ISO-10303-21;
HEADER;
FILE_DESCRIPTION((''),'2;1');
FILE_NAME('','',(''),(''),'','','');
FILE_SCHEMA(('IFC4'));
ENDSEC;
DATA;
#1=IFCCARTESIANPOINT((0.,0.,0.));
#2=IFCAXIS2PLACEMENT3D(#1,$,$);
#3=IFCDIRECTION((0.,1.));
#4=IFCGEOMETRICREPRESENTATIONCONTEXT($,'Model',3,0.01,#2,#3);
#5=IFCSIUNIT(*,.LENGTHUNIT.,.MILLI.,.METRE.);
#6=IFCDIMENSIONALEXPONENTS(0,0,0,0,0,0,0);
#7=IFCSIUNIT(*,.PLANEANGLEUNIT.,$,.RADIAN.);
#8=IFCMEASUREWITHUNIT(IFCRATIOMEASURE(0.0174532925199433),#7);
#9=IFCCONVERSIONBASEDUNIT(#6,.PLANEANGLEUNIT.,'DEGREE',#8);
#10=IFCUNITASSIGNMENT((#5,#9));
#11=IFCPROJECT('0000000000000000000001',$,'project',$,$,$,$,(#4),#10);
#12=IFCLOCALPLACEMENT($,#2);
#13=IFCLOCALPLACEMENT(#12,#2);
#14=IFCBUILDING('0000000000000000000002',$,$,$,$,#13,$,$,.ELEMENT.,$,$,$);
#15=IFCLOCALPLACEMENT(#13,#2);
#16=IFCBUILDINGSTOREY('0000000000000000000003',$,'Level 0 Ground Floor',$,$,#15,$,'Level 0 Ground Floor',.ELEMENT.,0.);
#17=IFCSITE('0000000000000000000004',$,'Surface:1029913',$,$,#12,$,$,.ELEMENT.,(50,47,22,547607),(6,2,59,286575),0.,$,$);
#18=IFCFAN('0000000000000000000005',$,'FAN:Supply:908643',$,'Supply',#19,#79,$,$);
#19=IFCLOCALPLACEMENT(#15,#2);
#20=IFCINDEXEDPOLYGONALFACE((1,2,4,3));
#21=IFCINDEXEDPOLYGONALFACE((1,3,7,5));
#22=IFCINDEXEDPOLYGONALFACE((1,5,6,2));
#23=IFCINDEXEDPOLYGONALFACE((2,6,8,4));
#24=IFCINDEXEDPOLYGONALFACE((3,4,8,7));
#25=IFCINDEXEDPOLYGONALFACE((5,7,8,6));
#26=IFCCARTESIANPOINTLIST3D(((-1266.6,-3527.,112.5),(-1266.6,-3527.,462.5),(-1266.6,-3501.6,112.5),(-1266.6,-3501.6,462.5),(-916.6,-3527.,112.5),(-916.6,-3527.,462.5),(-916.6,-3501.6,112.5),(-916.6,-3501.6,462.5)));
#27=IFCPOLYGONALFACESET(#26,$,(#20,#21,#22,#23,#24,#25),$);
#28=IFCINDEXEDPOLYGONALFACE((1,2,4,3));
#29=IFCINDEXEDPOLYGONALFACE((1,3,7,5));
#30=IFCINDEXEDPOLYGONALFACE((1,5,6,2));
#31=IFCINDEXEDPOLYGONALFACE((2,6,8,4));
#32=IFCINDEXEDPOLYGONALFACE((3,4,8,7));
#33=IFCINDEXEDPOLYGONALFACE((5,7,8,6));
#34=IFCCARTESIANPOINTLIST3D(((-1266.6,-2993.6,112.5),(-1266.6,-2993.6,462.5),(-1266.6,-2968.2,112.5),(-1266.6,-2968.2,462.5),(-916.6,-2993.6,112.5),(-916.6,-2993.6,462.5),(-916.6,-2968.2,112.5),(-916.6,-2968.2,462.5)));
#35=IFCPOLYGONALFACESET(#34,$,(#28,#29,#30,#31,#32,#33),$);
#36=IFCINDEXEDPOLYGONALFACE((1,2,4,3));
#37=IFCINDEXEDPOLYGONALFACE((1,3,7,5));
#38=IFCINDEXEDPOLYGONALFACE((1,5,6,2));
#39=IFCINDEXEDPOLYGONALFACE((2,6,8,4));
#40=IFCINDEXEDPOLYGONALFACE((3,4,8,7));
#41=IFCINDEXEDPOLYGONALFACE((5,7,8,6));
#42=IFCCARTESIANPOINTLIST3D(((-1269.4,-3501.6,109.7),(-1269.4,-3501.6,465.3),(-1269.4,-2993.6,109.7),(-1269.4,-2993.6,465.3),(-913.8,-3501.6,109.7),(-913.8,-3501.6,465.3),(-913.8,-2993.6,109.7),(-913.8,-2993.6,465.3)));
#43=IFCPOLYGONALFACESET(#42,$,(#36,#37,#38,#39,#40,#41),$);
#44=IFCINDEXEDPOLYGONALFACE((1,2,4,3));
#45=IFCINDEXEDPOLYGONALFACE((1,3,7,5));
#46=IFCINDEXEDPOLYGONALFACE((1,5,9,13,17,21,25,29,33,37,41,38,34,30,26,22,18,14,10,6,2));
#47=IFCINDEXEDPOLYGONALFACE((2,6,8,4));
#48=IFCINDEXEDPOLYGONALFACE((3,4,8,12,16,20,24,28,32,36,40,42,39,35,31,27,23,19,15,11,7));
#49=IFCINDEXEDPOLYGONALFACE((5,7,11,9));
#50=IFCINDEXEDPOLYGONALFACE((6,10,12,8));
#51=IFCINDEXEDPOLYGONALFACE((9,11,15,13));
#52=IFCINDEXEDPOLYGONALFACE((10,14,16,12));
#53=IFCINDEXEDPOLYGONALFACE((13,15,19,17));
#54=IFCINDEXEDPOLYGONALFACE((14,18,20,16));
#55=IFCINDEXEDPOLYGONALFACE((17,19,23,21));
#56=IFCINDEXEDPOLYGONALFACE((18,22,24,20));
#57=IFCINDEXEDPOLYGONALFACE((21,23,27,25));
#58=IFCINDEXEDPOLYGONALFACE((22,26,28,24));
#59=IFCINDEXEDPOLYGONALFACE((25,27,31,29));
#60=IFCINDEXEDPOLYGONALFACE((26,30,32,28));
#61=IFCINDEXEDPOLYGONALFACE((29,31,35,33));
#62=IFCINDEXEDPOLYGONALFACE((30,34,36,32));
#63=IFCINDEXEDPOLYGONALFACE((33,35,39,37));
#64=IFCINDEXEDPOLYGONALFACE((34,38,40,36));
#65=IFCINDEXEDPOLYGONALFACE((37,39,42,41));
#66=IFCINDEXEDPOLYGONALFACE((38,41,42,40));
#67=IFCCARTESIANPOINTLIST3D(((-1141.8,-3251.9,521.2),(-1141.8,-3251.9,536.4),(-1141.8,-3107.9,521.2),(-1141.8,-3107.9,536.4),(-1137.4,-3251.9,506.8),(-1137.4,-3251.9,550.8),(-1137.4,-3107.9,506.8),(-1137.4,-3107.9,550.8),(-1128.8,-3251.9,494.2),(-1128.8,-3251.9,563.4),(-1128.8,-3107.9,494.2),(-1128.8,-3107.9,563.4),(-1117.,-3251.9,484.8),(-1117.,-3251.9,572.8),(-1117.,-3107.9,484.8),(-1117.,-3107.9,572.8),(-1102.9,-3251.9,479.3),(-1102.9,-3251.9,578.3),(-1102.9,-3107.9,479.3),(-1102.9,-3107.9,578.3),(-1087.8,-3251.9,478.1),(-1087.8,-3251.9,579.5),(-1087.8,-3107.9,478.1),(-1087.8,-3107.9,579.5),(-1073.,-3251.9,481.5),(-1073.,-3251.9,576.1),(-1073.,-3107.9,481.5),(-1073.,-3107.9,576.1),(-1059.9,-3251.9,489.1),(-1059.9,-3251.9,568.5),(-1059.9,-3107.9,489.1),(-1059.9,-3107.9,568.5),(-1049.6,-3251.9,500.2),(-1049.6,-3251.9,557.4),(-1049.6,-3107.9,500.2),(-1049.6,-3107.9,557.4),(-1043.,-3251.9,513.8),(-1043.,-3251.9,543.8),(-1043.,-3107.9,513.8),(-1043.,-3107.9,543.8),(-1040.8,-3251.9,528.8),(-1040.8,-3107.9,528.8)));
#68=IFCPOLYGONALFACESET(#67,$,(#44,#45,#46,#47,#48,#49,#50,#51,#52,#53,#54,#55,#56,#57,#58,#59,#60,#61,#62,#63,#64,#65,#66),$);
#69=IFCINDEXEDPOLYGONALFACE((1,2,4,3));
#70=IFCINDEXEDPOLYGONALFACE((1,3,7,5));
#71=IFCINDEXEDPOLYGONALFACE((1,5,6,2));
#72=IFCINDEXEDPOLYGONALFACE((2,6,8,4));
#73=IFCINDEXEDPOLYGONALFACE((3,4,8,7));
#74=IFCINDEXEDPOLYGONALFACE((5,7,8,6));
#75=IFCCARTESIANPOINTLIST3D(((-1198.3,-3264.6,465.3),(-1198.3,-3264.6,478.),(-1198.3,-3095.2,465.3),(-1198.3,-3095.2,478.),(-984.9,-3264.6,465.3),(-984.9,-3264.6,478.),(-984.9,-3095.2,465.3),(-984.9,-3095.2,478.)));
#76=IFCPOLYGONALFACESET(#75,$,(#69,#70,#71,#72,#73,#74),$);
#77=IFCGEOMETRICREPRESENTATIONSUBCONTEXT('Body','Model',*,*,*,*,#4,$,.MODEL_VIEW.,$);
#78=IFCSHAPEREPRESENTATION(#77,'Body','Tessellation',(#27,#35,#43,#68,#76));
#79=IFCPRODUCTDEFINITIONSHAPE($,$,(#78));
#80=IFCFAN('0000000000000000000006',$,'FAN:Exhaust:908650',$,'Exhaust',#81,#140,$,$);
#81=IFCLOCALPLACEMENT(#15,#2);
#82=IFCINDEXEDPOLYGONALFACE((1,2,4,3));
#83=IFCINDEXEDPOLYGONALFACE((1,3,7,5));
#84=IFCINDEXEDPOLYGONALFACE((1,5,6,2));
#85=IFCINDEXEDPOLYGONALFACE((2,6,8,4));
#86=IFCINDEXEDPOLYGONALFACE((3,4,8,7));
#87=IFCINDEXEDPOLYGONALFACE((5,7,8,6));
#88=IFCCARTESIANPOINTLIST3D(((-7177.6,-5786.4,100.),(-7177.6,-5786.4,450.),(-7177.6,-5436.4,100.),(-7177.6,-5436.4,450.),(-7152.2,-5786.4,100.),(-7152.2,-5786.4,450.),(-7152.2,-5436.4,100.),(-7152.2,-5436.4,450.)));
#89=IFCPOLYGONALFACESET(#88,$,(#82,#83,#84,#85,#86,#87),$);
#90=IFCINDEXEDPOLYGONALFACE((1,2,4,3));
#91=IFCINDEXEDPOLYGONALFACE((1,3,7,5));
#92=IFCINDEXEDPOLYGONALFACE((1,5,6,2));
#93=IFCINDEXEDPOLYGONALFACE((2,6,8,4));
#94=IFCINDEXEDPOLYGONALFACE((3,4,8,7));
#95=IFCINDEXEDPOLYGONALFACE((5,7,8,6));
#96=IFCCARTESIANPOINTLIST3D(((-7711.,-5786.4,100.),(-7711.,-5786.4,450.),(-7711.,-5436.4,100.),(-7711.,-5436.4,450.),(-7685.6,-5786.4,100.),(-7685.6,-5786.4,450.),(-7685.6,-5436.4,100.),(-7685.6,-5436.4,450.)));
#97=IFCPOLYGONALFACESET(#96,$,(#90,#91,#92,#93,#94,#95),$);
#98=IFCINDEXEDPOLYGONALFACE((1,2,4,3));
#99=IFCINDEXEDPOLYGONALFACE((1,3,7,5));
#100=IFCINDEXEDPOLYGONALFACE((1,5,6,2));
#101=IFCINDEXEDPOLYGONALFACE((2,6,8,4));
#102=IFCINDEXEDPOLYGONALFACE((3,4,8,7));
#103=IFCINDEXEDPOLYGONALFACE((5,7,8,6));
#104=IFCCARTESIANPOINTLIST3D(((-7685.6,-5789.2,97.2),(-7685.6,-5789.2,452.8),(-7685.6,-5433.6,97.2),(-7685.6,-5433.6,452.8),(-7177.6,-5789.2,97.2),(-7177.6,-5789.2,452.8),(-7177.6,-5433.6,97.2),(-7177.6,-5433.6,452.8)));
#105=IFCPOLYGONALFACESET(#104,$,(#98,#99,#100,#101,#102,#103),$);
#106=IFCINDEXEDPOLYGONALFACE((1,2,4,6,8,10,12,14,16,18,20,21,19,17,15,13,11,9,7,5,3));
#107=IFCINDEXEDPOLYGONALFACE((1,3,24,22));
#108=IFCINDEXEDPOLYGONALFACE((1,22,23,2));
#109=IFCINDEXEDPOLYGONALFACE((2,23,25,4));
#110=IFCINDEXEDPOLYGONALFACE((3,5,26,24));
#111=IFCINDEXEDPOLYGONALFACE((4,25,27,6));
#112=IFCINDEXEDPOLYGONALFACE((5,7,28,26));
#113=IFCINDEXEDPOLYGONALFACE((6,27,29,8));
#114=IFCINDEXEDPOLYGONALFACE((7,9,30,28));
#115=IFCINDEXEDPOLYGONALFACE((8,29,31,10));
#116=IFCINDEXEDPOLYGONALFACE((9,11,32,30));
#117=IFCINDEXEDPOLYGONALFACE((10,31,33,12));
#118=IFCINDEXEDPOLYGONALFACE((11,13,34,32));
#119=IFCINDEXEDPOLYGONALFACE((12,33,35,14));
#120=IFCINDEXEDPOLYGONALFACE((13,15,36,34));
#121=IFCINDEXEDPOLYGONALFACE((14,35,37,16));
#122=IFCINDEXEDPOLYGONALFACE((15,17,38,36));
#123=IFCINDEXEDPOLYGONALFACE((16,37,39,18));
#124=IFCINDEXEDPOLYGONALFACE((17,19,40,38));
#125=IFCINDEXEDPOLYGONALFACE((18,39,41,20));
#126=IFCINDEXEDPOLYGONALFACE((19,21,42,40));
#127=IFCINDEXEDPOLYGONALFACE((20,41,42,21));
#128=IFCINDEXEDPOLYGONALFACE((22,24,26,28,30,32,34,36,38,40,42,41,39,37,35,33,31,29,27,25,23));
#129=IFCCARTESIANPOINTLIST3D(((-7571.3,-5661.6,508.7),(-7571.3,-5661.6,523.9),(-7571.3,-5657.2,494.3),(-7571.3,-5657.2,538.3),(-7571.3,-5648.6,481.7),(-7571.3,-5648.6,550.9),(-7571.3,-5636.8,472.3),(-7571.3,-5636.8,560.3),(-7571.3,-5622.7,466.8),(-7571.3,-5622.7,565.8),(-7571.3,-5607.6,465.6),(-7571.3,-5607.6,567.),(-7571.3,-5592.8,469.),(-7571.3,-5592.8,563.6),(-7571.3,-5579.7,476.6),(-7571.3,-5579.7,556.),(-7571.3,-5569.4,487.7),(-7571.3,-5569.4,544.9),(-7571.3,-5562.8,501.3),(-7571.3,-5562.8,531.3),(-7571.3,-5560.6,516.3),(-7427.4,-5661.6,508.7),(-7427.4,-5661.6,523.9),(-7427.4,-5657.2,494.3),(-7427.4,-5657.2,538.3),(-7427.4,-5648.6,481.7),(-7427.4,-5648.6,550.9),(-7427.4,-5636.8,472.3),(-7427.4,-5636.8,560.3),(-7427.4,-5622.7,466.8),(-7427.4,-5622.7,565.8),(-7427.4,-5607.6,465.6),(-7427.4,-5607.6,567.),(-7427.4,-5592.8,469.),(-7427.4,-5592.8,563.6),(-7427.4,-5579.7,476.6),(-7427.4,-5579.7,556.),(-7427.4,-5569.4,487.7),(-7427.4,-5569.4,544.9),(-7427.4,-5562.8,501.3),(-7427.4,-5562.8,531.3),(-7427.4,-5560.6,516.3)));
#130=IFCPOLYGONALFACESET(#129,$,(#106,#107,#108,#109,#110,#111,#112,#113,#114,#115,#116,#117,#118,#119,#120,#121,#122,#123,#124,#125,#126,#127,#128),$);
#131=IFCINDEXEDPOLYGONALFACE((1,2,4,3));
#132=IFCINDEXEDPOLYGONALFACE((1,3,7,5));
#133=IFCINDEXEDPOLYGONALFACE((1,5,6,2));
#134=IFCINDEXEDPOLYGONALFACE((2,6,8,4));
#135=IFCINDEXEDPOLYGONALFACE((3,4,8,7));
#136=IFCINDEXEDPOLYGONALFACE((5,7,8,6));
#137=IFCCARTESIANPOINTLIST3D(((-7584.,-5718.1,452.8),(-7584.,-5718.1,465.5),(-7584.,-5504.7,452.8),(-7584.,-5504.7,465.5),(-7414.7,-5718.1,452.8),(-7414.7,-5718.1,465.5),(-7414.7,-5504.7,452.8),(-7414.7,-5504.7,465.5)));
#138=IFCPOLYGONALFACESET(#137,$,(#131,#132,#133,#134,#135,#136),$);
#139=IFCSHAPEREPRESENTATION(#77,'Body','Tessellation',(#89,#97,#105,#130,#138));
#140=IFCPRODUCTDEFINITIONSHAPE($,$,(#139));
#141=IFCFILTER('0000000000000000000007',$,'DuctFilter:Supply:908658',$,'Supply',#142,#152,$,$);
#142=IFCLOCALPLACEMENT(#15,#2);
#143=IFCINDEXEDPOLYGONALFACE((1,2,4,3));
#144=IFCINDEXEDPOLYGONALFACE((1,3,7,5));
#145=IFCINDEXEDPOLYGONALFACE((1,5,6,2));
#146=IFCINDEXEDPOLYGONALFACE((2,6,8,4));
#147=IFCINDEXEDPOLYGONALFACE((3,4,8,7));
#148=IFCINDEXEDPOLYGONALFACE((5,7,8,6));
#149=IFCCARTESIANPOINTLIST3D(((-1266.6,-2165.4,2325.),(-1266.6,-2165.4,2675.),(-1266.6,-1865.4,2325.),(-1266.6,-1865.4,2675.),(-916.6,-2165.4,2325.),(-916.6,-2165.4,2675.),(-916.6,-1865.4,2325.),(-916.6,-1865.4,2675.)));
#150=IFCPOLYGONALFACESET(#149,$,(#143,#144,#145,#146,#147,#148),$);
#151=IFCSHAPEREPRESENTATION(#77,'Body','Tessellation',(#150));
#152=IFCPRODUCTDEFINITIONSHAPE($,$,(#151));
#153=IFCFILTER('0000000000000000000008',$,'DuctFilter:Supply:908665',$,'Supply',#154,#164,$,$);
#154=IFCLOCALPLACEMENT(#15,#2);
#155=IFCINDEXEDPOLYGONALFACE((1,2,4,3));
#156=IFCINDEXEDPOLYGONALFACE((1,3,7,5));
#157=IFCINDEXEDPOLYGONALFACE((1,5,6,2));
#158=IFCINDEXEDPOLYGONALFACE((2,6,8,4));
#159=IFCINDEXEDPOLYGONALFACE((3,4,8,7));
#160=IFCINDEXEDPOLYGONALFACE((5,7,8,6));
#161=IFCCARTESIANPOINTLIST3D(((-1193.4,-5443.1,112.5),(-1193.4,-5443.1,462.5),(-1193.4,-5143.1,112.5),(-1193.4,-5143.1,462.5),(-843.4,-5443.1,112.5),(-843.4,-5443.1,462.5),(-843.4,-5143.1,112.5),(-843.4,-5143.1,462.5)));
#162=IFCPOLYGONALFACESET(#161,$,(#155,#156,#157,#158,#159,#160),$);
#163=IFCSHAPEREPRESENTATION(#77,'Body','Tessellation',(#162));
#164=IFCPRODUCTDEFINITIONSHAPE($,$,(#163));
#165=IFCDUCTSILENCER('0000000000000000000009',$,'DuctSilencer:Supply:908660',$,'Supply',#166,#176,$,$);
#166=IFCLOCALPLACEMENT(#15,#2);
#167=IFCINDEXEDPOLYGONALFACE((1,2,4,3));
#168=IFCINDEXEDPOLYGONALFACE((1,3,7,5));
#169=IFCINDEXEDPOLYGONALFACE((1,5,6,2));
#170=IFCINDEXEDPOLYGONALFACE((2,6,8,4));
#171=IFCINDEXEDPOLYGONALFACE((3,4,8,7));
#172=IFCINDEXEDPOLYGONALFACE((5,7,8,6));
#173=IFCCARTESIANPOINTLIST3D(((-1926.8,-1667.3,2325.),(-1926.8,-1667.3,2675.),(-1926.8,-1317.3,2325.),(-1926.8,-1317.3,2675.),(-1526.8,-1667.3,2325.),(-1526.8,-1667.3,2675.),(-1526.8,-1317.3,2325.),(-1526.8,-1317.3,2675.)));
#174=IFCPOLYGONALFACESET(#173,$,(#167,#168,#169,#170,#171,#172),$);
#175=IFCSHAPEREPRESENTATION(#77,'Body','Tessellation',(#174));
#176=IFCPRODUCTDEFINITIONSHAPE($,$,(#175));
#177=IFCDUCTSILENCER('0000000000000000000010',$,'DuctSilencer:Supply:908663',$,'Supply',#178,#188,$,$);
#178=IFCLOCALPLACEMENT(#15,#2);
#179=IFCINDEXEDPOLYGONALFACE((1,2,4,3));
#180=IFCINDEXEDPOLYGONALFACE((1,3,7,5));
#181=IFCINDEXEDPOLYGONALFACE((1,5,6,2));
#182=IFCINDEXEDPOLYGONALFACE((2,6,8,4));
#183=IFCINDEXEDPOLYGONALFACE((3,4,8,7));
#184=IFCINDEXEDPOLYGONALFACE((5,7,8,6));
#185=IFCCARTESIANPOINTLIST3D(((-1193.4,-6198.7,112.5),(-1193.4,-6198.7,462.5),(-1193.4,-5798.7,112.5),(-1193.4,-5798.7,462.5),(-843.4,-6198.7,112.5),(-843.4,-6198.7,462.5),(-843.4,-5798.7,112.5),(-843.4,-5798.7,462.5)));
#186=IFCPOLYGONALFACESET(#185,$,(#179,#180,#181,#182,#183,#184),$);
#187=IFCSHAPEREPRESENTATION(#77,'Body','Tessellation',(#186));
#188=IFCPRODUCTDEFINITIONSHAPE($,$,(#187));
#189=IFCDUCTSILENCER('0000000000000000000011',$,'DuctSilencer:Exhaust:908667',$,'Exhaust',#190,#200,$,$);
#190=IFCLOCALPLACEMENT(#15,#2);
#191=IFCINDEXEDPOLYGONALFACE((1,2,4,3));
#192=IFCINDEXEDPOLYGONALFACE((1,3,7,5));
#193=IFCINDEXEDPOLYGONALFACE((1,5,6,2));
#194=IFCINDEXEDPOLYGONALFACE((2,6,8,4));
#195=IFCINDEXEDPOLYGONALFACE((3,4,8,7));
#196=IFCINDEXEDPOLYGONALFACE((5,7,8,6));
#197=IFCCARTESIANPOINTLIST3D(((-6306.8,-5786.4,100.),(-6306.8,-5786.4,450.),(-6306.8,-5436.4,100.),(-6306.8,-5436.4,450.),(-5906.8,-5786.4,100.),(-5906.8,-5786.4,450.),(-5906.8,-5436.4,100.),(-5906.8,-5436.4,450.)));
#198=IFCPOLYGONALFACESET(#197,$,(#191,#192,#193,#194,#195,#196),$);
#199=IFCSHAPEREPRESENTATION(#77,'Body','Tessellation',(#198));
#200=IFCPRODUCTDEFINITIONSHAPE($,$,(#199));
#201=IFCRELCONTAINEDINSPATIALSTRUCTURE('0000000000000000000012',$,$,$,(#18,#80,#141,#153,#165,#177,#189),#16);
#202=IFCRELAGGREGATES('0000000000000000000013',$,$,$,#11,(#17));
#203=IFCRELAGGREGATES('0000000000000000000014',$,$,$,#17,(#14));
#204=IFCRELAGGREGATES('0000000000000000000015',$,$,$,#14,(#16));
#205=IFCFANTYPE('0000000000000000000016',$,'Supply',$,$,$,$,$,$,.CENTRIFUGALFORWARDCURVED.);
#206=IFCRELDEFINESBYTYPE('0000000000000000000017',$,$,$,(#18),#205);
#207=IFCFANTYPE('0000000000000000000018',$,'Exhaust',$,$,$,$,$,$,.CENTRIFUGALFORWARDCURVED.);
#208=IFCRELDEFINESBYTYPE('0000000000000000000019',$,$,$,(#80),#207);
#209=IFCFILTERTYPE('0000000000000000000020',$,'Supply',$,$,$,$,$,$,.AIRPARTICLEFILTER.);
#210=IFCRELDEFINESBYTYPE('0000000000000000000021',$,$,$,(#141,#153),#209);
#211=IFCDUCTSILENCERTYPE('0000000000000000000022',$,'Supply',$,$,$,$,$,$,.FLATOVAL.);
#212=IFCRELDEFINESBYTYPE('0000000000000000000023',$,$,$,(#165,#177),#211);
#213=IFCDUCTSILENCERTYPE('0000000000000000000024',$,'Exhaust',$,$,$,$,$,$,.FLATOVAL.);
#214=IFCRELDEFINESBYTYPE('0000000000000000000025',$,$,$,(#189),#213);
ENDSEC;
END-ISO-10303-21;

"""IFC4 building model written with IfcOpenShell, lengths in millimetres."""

from ifc_helpers import new_model, entity, si_unit, converted_unit, direction, frame, frame_2d, origin, origin_2d_with_axis, place, context, subcontext, project, spatial, rectangle, circle, extrude, source, transform, mapped, type_object, type_shapes, element, save


model = new_model("IFC4")

# Units and contexts
model_context = context("Model", 3, precision=0.01, world=origin(), true_north=direction((0.0, 1.0)))
body_context = subcontext(model_context, "Body", "Model", "MODEL_VIEW")
ifc_project = project(units=[si_unit("LENGTHUNIT", "METRE", prefix="MILLI"), converted_unit("PLANEANGLEUNIT", "DEGREE", entity("IfcRatioMeasure", 0.0174532925199433), si_unit("PLANEANGLEUNIT", "RADIAN"), dimensions=[0, 0, 0, 0, 0, 0, 0])], contexts=[model_context])

# Site, building, storey
site_placement = place(None, origin())
site = spatial("IfcSite", under=ifc_project, at=site_placement, Name="Surface:1029913", CompositionType="ELEMENT", RefLatitude=(50, 47, 22, 547607), RefLongitude=(6, 2, 59, 286575), RefElevation=0.0)
building_placement = place(site_placement, origin())
building = spatial("IfcBuilding", under=site, at=building_placement, CompositionType="ELEMENT")
storey_placement = place(building_placement, origin())
storey = spatial("IfcBuildingStorey", under=building, at=storey_placement, Name="Level 0 Ground Floor", LongName="Level 0 Ground Floor", CompositionType="ELEMENT", Elevation=0.0)

# Fans
fan_type_1 = type_object("IfcFanType", Name="Supply", PredefinedType="CENTRIFUGALFORWARDCURVED")
shared_shape_1 = source(origin(), body_context, "Body", "SweptSolid", [
    extrude(rectangle(XDim=350.0, YDim=25.4, at=origin_2d_with_axis()), frame((0.0, -520.7, 2.8), z_axis=(0.0, 0.0, 1.0), x_axis=(-1.0, 0.0, 0.0)), (0.0, 0.0, 1.0), 350.0),
    extrude(rectangle(XDim=350.0, YDim=25.4, at=frame_2d((0.0, 0.0), x_axis=(1.0, 0.0))), frame((0.0, 12.7, 2.8), z_axis=(0.0, 0.0, 1.0), x_axis=(-1.0, 0.0, 0.0)), (0.0, 0.0, 1.0), 350.0),
    extrude(rectangle(XDim=355.6, YDim=508.0, at=origin_2d_with_axis()), frame((0.0, -254.0, 0.0), z_axis=(0.0, 0.0, 1.0), x_axis=(-1.0, 0.0, 0.0)), (0.0, 0.0, 1.0), 355.6),
    extrude(circle(Radius=50.8, at=frame_2d((0.0, 0.0), x_axis=(1.0, 0.0))), frame((0.0, -258.2, 419.1), z_axis=(0.0, 1.0, 0.0), x_axis=(1.0, 0.0, 0.0)), (0.0, 0.0, 1.0), 143.9),
    extrude(rectangle(XDim=213.4, YDim=169.3, at=origin_2d_with_axis()), frame((0.0, -186.3, 355.6), z_axis=(0.0, 0.0, 1.0), x_axis=(-1.0, 0.0, 0.0)), (0.0, 0.0, 1.0), 12.7),
])
type_shapes(fan_type_1, [shared_shape_1])
fan_1_placement = place(storey_placement, frame((-1091.6, -2993.6, 109.7)))
element("IfcFan", 1, at=fan_1_placement, inside=storey, type_object=fan_type_1, Name="FAN:Supply:908643", ObjectType="Supply", context=body_context, shape_type="MappedRepresentation", body=[
    mapped(shared_shape_1, transform((0.0, 0.0, 0.0), scale=1.0)),
])
fan_type_2 = type_object("IfcFanType", Name="Exhaust", PredefinedType="CENTRIFUGALFORWARDCURVED")
shared_shape_2 = source(origin(), body_context, "Body", "SweptSolid", [
    extrude(rectangle(XDim=350.0, YDim=25.4, at=origin_2d_with_axis()), frame((0.0, -520.7, 2.8), z_axis=(0.0, 0.0, 1.0), x_axis=(-1.0, 0.0, 0.0)), (0.0, 0.0, 1.0), 350.0),
    extrude(rectangle(XDim=350.0, YDim=25.4, at=frame_2d((0.0, 0.0), x_axis=(1.0, 0.0))), frame((0.0, 12.7, 2.8), z_axis=(0.0, 0.0, 1.0), x_axis=(-1.0, 0.0, 0.0)), (0.0, 0.0, 1.0), 350.0),
    extrude(rectangle(XDim=355.6, YDim=508.0, at=origin_2d_with_axis()), frame((0.0, -254.0, 0.0), z_axis=(0.0, 0.0, 1.0), x_axis=(-1.0, 0.0, 0.0)), (0.0, 0.0, 1.0), 355.6),
    extrude(circle(Radius=50.8, at=frame_2d((0.0, 0.0), x_axis=(1.0, 0.0))), frame((0.0, -258.2, 419.1), z_axis=(0.0, 1.0, 0.0), x_axis=(1.0, 0.0, 0.0)), (0.0, 0.0, 1.0), 143.9),
    extrude(rectangle(XDim=213.4, YDim=169.3, at=origin_2d_with_axis()), frame((0.0, -186.3, 355.6), z_axis=(0.0, 0.0, 1.0), x_axis=(-1.0, 0.0, 0.0)), (0.0, 0.0, 1.0), 12.7),
])
type_shapes(fan_type_2, [shared_shape_2])
fan_2_placement = place(storey_placement, frame((-7685.6, -5611.4, 97.2), z_axis=(0.0, 0.0, 1.0), x_axis=(0.0, 1.0, 0.0)))
element("IfcFan", 2, at=fan_2_placement, inside=storey, type_object=fan_type_2, Name="FAN:Exhaust:908650", ObjectType="Exhaust", context=body_context, shape_type="MappedRepresentation", body=[
    mapped(shared_shape_2, transform((0.0, 0.0, 0.0), scale=1.0)),
])

# Filters
filter_type_1 = type_object("IfcFilterType", Name="Supply", PredefinedType="AIRPARTICLEFILTER")
shared_shape_3 = source(origin(), body_context, "Body", "SweptSolid", [
    extrude(rectangle(XDim=300.0, YDim=350.0, at=origin_2d_with_axis()), frame((0.0, 0.0, -175.0), z_axis=(0.0, 0.0, 1.0), x_axis=(-1.0, 0.0, 0.0)), (0.0, 0.0, 1.0), 350.0),
])
type_shapes(filter_type_1, [shared_shape_3])
for number, where, z_axis, x_axis, name in (
    (3, (-1091.6, -2015.4, 2500.0), (0.0, 0.0, 1.0), (0.0, 1.0, 0.0), "DuctFilter:Supply:908658"),
    (4, (-1018.4, -5293.1, 287.5), (0.0, 0.0, 1.0), (0.0, 1.0, 0.0), "DuctFilter:Supply:908665"),
):
    element("IfcFilter", number, at=place(storey_placement, frame(where, z_axis=z_axis, x_axis=x_axis)), inside=storey, type_object=filter_type_1, Name=name, ObjectType="Supply", context=body_context, shape_type="MappedRepresentation", body=[
        mapped(shared_shape_3, transform((0.0, 0.0, 0.0), scale=1.0)),
    ])

# Duct silencers
duct_silencer_type_1 = type_object("IfcDuctSilencerType", Name="Supply", PredefinedType="FLATOVAL")
shared_shape_4 = source(origin(), body_context, "Body", "SweptSolid", [
    extrude(rectangle(XDim=400.0, YDim=350.0, at=frame_2d((0.0, 0.0), x_axis=(1.0, 0.0))), frame((0.0, 0.0, -175.0), z_axis=(0.0, 0.0, 1.0), x_axis=(-1.0, 0.0, 0.0)), (0.0, 0.0, 1.0), 350.0),
])
type_shapes(duct_silencer_type_1, [shared_shape_4])
duct_silencer_1_placement = place(storey_placement, frame((-1726.8, -1492.3, 2500.0)))
element("IfcDuctSilencer", 5, at=duct_silencer_1_placement, inside=storey, type_object=duct_silencer_type_1, Name="DuctSilencer:Supply:908660", ObjectType="Supply", context=body_context, shape_type="MappedRepresentation", body=[
    mapped(shared_shape_4, transform((0.0, 0.0, 0.0), scale=1.0)),
])
duct_silencer_2_placement = place(storey_placement, frame((-1018.4, -5998.7, 287.5), z_axis=(0.0, 0.0, 1.0), x_axis=(0.0, -1.0, 0.0)))
element("IfcDuctSilencer", 6, at=duct_silencer_2_placement, inside=storey, type_object=duct_silencer_type_1, Name="DuctSilencer:Supply:908663", ObjectType="Supply", context=body_context, shape_type="MappedRepresentation", body=[
    mapped(shared_shape_4, transform((0.0, 0.0, 0.0), scale=1.0)),
])
duct_silencer_type_2 = type_object("IfcDuctSilencerType", Name="Exhaust", PredefinedType="FLATOVAL")
shared_shape_5 = source(origin(), body_context, "Body", "SweptSolid", [
    extrude(rectangle(XDim=400.0, YDim=350.0, at=frame_2d((0.0, 0.0), x_axis=(1.0, 0.0))), frame((0.0, 0.0, -175.0), z_axis=(0.0, 0.0, 1.0), x_axis=(-1.0, 0.0, 0.0)), (0.0, 0.0, 1.0), 350.0),
])
type_shapes(duct_silencer_type_2, [shared_shape_5])
duct_silencer_3_placement = place(storey_placement, frame((-6106.8, -5611.4, 275.0)))
element("IfcDuctSilencer", 7, at=duct_silencer_3_placement, inside=storey, type_object=duct_silencer_type_2, Name="DuctSilencer:Exhaust:908667", ObjectType="Exhaust", context=body_context, shape_type="MappedRepresentation", body=[
    mapped(shared_shape_5, transform((0.0, 0.0, 0.0), scale=1.0)),
])

save(model, "model.ifc")
